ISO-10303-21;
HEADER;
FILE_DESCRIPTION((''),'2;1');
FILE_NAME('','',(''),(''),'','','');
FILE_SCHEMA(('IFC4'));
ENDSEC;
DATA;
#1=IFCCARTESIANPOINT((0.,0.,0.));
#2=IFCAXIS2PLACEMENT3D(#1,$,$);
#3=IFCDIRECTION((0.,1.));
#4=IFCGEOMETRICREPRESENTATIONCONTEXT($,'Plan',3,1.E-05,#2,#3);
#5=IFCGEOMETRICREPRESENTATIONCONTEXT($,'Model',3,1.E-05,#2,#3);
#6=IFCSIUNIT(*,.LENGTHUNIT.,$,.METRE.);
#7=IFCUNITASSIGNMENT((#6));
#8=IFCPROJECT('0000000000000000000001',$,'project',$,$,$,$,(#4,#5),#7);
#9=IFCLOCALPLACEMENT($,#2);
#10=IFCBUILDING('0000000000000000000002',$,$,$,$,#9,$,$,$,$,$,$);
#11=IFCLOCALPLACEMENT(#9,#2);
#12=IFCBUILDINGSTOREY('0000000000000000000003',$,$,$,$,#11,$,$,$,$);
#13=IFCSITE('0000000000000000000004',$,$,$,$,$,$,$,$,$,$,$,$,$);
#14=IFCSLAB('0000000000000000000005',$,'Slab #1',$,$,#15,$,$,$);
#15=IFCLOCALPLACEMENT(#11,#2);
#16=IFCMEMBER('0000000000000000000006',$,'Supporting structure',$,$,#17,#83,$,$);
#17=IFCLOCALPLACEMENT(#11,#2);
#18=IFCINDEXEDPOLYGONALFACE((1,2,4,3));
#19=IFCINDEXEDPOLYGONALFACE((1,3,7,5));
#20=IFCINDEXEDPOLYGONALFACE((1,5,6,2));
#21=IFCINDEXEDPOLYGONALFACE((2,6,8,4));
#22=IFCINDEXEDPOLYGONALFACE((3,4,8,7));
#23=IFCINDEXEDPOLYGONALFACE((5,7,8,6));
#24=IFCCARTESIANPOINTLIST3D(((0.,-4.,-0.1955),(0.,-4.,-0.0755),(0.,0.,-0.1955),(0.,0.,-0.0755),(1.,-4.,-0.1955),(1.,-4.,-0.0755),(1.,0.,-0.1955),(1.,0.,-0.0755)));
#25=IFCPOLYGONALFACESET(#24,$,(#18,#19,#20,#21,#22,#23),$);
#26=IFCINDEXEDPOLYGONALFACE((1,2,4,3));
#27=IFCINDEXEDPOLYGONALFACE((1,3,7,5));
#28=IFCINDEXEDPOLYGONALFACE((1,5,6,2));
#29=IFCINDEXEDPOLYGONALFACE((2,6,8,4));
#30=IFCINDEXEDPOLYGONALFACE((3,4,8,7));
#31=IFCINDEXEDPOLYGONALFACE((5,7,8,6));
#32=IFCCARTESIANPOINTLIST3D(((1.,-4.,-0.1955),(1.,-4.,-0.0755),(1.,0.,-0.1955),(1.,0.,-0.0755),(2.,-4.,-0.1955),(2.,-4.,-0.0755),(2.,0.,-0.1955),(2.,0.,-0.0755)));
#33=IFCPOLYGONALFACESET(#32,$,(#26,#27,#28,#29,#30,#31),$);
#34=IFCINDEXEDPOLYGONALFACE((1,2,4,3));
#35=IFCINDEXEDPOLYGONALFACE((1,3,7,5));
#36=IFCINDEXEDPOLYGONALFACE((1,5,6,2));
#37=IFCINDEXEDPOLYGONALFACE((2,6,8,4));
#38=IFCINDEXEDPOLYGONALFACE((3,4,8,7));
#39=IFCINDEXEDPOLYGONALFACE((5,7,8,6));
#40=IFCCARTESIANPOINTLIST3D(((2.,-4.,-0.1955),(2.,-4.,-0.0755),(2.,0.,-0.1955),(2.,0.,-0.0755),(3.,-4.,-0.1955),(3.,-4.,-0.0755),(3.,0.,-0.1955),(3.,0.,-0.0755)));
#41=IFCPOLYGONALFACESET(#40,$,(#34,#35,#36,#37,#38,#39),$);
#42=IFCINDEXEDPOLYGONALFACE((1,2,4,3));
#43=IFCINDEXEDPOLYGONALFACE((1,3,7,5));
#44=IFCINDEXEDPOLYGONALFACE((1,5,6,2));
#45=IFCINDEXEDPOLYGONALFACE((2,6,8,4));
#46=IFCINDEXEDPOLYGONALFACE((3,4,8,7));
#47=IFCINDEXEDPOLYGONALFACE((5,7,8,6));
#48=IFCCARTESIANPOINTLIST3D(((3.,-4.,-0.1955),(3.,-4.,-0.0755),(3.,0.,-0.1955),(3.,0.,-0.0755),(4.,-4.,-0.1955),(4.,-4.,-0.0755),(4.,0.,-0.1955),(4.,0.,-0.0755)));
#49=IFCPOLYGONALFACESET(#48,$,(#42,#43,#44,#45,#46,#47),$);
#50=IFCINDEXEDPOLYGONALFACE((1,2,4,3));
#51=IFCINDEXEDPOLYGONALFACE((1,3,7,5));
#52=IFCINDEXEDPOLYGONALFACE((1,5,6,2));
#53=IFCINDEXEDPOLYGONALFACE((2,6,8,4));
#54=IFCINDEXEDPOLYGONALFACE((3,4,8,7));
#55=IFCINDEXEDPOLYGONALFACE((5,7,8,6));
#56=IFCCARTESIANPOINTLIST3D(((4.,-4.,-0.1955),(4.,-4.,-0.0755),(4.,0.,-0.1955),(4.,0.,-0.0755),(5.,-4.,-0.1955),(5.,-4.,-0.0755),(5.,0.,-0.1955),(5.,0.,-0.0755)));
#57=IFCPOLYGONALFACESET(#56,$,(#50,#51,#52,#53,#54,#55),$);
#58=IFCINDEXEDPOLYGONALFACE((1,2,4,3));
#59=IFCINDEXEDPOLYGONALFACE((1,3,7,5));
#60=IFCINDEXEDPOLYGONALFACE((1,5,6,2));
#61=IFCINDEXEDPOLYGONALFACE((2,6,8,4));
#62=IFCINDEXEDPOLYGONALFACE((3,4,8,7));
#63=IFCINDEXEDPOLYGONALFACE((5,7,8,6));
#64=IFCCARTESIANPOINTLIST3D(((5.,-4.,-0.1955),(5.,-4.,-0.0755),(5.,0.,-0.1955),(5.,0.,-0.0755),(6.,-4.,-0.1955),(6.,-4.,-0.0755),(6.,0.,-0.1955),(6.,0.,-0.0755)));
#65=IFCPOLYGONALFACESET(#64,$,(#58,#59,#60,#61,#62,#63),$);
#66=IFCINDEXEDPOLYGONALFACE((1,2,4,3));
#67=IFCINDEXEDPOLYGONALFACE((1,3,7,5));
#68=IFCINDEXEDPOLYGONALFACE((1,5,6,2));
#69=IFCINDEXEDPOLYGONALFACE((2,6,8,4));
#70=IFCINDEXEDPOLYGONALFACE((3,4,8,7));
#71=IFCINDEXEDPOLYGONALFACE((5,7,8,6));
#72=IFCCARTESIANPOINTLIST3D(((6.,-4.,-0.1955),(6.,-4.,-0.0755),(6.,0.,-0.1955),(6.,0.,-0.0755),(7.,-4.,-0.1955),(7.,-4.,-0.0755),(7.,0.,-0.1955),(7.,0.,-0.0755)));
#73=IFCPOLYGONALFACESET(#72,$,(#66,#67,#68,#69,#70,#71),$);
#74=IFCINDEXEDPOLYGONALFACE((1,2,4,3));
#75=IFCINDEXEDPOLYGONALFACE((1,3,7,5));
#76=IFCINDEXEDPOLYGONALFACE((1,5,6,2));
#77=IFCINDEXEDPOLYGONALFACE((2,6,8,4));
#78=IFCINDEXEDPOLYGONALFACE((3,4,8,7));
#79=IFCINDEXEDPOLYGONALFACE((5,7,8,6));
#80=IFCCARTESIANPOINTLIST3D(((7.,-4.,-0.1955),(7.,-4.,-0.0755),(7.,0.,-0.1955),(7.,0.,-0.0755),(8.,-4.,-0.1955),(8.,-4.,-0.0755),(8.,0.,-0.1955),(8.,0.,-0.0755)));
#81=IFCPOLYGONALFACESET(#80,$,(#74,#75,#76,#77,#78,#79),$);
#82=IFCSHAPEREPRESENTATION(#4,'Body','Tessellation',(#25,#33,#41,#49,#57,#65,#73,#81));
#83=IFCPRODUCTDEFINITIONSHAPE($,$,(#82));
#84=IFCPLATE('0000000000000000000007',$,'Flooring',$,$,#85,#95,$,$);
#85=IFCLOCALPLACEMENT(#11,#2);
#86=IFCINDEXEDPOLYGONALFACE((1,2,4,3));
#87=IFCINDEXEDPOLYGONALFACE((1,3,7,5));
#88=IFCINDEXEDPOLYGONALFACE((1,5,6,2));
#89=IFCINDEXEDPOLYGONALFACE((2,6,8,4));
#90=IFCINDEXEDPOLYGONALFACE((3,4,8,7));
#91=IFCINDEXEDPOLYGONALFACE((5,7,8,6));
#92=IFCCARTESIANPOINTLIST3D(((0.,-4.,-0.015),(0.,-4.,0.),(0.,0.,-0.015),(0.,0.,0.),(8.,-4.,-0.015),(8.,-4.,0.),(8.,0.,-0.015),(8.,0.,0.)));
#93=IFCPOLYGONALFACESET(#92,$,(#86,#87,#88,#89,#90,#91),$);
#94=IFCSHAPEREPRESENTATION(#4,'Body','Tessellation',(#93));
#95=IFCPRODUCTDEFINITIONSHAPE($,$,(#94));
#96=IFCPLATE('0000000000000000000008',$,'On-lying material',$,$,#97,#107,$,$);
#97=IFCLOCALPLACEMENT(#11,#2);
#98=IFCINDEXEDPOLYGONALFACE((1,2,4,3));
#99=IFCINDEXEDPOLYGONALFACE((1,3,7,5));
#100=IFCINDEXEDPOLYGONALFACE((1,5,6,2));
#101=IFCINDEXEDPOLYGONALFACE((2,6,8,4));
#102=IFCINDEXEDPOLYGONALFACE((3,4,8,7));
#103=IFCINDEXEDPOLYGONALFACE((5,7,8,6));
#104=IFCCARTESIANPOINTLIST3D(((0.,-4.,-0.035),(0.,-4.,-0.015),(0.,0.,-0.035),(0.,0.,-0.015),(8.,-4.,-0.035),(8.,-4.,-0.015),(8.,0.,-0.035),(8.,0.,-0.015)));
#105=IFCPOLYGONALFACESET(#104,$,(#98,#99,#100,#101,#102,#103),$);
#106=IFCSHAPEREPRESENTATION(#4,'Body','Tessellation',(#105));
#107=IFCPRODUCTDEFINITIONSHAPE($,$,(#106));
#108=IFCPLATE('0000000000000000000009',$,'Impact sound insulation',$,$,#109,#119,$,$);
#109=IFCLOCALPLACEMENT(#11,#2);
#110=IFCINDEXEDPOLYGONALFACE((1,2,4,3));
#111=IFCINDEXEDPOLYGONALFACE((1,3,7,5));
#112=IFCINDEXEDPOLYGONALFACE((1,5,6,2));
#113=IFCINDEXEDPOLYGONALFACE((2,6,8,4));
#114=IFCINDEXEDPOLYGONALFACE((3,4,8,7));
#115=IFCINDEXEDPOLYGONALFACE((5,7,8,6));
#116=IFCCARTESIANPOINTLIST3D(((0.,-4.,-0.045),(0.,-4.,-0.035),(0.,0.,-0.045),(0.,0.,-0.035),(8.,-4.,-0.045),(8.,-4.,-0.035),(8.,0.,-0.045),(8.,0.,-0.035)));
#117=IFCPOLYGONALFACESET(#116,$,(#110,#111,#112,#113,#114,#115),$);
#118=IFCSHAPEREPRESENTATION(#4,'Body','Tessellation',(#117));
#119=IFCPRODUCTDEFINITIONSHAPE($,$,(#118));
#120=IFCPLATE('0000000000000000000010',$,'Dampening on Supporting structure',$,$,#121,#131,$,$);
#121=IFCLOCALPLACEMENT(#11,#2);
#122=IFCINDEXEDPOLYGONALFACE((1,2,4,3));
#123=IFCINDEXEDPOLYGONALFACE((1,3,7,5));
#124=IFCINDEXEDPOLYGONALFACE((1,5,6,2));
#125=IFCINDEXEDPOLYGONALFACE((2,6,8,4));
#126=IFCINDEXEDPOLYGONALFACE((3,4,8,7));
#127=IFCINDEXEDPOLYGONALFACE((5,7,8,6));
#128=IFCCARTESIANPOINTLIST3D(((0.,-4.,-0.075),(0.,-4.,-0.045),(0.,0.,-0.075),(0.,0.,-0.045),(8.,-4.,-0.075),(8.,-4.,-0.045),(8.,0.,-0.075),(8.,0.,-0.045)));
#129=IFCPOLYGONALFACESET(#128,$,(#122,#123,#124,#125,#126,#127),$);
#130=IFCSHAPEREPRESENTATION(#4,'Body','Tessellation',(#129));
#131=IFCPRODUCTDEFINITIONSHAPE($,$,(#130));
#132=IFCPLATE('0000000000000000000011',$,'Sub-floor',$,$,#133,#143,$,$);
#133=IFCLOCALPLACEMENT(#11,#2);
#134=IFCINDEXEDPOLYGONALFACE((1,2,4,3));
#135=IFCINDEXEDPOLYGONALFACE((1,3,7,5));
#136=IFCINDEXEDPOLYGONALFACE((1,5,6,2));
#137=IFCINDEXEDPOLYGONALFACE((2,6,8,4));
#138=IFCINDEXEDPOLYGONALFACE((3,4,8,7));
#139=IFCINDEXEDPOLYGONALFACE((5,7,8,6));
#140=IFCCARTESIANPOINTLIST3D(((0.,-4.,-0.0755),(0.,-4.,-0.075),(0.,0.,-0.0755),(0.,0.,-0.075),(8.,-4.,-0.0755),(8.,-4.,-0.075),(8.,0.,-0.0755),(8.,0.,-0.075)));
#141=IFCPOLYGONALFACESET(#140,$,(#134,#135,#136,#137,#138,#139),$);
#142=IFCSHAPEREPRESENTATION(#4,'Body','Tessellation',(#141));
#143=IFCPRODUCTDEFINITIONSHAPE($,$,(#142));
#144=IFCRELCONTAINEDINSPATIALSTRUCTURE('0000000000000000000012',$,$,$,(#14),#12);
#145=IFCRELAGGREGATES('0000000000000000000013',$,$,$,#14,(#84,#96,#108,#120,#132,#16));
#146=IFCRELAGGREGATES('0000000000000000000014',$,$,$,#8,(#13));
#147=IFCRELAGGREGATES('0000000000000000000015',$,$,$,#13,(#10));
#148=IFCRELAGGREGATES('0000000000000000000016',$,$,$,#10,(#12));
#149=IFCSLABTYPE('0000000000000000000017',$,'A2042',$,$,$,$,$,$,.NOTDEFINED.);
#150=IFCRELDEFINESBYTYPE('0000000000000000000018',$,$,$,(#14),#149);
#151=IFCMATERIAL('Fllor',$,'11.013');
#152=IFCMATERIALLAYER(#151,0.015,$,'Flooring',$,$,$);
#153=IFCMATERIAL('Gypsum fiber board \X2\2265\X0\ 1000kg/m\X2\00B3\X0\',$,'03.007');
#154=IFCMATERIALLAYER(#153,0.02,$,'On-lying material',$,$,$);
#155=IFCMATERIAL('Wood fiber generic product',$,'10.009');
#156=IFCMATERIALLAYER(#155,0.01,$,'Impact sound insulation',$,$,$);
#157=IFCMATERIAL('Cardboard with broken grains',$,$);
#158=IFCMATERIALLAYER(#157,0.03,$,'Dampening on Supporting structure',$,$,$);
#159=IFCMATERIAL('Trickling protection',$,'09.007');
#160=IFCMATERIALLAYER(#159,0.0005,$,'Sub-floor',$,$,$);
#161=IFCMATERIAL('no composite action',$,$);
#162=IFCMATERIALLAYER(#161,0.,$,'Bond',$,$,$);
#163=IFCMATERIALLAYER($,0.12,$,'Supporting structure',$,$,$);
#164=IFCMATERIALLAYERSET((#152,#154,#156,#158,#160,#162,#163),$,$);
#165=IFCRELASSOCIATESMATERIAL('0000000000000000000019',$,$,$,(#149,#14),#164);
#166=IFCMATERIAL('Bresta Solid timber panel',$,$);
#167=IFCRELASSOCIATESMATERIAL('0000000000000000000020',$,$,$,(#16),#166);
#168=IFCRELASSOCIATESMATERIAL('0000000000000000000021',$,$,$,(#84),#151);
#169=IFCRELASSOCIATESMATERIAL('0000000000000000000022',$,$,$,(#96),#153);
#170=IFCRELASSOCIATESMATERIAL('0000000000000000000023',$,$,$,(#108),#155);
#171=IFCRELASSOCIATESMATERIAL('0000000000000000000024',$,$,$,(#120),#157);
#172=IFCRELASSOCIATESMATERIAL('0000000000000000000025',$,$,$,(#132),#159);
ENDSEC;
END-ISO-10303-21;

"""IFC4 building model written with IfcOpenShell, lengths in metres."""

from ifc_helpers import new_model, si_unit, direction, frame, frame_2d, origin, origin_with_axes, place, context, project, spatial, rectangle, extrude, material, layer, layer_set, type_object, element, aggregate, save


model = new_model("IFC4")

# Units and contexts
plan_context = context("Plan", 3, precision=1e-05, world=origin(), true_north=direction((0.0, 1.0)))
model_context = context("Model", 3, precision=1e-05, world=origin(), true_north=direction((0.0, 1.0)))
ifc_project = project(units=[si_unit("LENGTHUNIT", "METRE")], contexts=[plan_context, model_context])

# Site, building, storey
site = spatial("IfcSite", under=ifc_project)
building_placement = place(None, origin())
building = spatial("IfcBuilding", under=site, at=building_placement)
storey_placement = place(building_placement, origin())
storey = spatial("IfcBuildingStorey", under=building, at=storey_placement)

# Slab, member, plates
ifc_material_1 = material(Name="Fllor", Category="11.013")
ifc_layer_1 = layer(ifc_material_1, 0.015, Name="Flooring")
ifc_material_2 = material(Name="Gypsum fiber board ≥ 1000kg/m³", Category="03.007")
ifc_layer_2 = layer(ifc_material_2, 0.02, Name="On-lying material")
ifc_material_3 = material(Name="Wood fiber generic product", Category="10.009")
ifc_layer_3 = layer(ifc_material_3, 0.01, Name="Impact sound insulation")
ifc_material_4 = material(Name="Cardboard with broken grains")
ifc_layer_4 = layer(ifc_material_4, 0.03, Name="Dampening on Supporting structure")
ifc_material_5 = material(Name="Trickling protection", Category="09.007")
ifc_layer_5 = layer(ifc_material_5, 0.0005, Name="Sub-floor")
ifc_material_6 = material(Name="no composite action")
ifc_layer_6 = layer(ifc_material_6, 0.0, Name="Bond")
ifc_layer_7 = layer(None, 0.12, Name="Supporting structure")
ifc_layer_set = layer_set([ifc_layer_1, ifc_layer_2, ifc_layer_3, ifc_layer_4, ifc_layer_5, ifc_layer_6, ifc_layer_7])
slab_type = type_object("IfcSlabType", Name="A2042", PredefinedType="NOTDEFINED", material=ifc_layer_set)
slab_placement = place(None, frame((0.0, 0.0, 0.0), z_axis=(0.0, 0.0, -1.0), x_axis=(1.0, 0.0, 0.0)))
slab = element("IfcSlab", 1, at=slab_placement, inside=storey, type_object=slab_type, material=ifc_layer_set, Name="Slab #1")
ifc_material_7 = material(Name="Bresta Solid timber panel")
member_placement = place(slab_placement, origin())
member = element("IfcMember", 2, at=member_placement, material=ifc_material_7, Name="Supporting structure", context=plan_context, shape_type="SweptSolid", body=[
    extrude(rectangle(XDim=1.0, YDim=0.12, at=frame_2d((0.5, 0.06), x_axis=(1.0, 0.0))), frame((0.0, 4.0, 0.0755), z_axis=(0.0, -1.0, 0.0), x_axis=(1.0, 0.0, 0.0)), (0.0, 0.0, 1.0), 4.0),
    extrude(rectangle(XDim=1.0, YDim=0.12, at=frame_2d((0.5, 0.06), x_axis=(1.0, 0.0))), frame((1.0, 4.0, 0.0755), z_axis=(0.0, -1.0, 0.0), x_axis=(1.0, 0.0, 0.0)), (0.0, 0.0, 1.0), 4.0),
    extrude(rectangle(XDim=1.0, YDim=0.12, at=frame_2d((0.5, 0.06), x_axis=(1.0, 0.0))), frame((2.0, 4.0, 0.0755), z_axis=(0.0, -1.0, 0.0), x_axis=(1.0, 0.0, 0.0)), (0.0, 0.0, 1.0), 4.0),
    extrude(rectangle(XDim=1.0, YDim=0.12, at=frame_2d((0.5, 0.06), x_axis=(1.0, 0.0))), frame((3.0, 4.0, 0.0755), z_axis=(0.0, -1.0, 0.0), x_axis=(1.0, 0.0, 0.0)), (0.0, 0.0, 1.0), 4.0),
    extrude(rectangle(XDim=1.0, YDim=0.12, at=frame_2d((0.5, 0.06), x_axis=(1.0, 0.0))), frame((4.0, 4.0, 0.0755), z_axis=(0.0, -1.0, 0.0), x_axis=(1.0, 0.0, 0.0)), (0.0, 0.0, 1.0), 4.0),
    extrude(rectangle(XDim=1.0, YDim=0.12, at=frame_2d((0.5, 0.06), x_axis=(1.0, 0.0))), frame((5.0, 4.0, 0.0755), z_axis=(0.0, -1.0, 0.0), x_axis=(1.0, 0.0, 0.0)), (0.0, 0.0, 1.0), 4.0),
    extrude(rectangle(XDim=1.0, YDim=0.12, at=frame_2d((0.5, 0.06), x_axis=(1.0, 0.0))), frame((6.0, 4.0, 0.0755), z_axis=(0.0, -1.0, 0.0), x_axis=(1.0, 0.0, 0.0)), (0.0, 0.0, 1.0), 4.0),
    extrude(rectangle(XDim=1.0, YDim=0.12, at=frame_2d((0.5, 0.06), x_axis=(1.0, 0.0))), frame((7.0, 4.0, 0.0755), z_axis=(0.0, -1.0, 0.0), x_axis=(1.0, 0.0, 0.0)), (0.0, 0.0, 1.0), 4.0),
])
plate_1_placement = place(slab_placement, origin())
plate_1 = element("IfcPlate", 3, at=plate_1_placement, material=ifc_material_1, Name="Flooring", context=plan_context, shape_type="SweptSolid", body=[
    extrude(rectangle(XDim=8.0, YDim=4.0, at=frame_2d((4.0, 2.0), x_axis=(1.0, 0.0))), origin_with_axes(), (0.0, 0.0, 1.0), 0.015),
])
plate_2_placement = place(slab_placement, origin())
plate_2 = element("IfcPlate", 4, at=plate_2_placement, material=ifc_material_2, Name="On-lying material", context=plan_context, shape_type="SweptSolid", body=[
    extrude(rectangle(XDim=8.0, YDim=4.0, at=frame_2d((4.0, 2.0), x_axis=(1.0, 0.0))), frame((0.0, 0.0, 0.015), z_axis=(0.0, 0.0, 1.0), x_axis=(1.0, 0.0, 0.0)), (0.0, 0.0, 1.0), 0.02),
])
plate_3_placement = place(slab_placement, origin())
plate_3 = element("IfcPlate", 5, at=plate_3_placement, material=ifc_material_3, Name="Impact sound insulation", context=plan_context, shape_type="SweptSolid", body=[
    extrude(rectangle(XDim=8.0, YDim=4.0, at=frame_2d((4.0, 2.0), x_axis=(1.0, 0.0))), frame((0.0, 0.0, 0.035), z_axis=(0.0, 0.0, 1.0), x_axis=(1.0, 0.0, 0.0)), (0.0, 0.0, 1.0), 0.01),
])
plate_4_placement = place(slab_placement, origin())
plate_4 = element("IfcPlate", 6, at=plate_4_placement, material=ifc_material_4, Name="Dampening on Supporting structure", context=plan_context, shape_type="SweptSolid", body=[
    extrude(rectangle(XDim=8.0, YDim=4.0, at=frame_2d((4.0, 2.0), x_axis=(1.0, 0.0))), frame((0.0, 0.0, 0.045), z_axis=(0.0, 0.0, 1.0), x_axis=(1.0, 0.0, 0.0)), (0.0, 0.0, 1.0), 0.03),
])
plate_5_placement = place(slab_placement, origin())
plate_5 = element("IfcPlate", 7, at=plate_5_placement, material=ifc_material_5, Name="Sub-floor", context=plan_context, shape_type="SweptSolid", body=[
    extrude(rectangle(XDim=8.0, YDim=4.0, at=frame_2d((4.0, 2.0), x_axis=(1.0, 0.0))), frame((0.0, 0.0, 0.075), z_axis=(0.0, 0.0, 1.0), x_axis=(1.0, 0.0, 0.0)), (0.0, 0.0, 1.0), 0.0005),
])
aggregate(slab, [plate_1, plate_2, plate_3, plate_4, plate_5, member])

save(model, "model.ifc")
